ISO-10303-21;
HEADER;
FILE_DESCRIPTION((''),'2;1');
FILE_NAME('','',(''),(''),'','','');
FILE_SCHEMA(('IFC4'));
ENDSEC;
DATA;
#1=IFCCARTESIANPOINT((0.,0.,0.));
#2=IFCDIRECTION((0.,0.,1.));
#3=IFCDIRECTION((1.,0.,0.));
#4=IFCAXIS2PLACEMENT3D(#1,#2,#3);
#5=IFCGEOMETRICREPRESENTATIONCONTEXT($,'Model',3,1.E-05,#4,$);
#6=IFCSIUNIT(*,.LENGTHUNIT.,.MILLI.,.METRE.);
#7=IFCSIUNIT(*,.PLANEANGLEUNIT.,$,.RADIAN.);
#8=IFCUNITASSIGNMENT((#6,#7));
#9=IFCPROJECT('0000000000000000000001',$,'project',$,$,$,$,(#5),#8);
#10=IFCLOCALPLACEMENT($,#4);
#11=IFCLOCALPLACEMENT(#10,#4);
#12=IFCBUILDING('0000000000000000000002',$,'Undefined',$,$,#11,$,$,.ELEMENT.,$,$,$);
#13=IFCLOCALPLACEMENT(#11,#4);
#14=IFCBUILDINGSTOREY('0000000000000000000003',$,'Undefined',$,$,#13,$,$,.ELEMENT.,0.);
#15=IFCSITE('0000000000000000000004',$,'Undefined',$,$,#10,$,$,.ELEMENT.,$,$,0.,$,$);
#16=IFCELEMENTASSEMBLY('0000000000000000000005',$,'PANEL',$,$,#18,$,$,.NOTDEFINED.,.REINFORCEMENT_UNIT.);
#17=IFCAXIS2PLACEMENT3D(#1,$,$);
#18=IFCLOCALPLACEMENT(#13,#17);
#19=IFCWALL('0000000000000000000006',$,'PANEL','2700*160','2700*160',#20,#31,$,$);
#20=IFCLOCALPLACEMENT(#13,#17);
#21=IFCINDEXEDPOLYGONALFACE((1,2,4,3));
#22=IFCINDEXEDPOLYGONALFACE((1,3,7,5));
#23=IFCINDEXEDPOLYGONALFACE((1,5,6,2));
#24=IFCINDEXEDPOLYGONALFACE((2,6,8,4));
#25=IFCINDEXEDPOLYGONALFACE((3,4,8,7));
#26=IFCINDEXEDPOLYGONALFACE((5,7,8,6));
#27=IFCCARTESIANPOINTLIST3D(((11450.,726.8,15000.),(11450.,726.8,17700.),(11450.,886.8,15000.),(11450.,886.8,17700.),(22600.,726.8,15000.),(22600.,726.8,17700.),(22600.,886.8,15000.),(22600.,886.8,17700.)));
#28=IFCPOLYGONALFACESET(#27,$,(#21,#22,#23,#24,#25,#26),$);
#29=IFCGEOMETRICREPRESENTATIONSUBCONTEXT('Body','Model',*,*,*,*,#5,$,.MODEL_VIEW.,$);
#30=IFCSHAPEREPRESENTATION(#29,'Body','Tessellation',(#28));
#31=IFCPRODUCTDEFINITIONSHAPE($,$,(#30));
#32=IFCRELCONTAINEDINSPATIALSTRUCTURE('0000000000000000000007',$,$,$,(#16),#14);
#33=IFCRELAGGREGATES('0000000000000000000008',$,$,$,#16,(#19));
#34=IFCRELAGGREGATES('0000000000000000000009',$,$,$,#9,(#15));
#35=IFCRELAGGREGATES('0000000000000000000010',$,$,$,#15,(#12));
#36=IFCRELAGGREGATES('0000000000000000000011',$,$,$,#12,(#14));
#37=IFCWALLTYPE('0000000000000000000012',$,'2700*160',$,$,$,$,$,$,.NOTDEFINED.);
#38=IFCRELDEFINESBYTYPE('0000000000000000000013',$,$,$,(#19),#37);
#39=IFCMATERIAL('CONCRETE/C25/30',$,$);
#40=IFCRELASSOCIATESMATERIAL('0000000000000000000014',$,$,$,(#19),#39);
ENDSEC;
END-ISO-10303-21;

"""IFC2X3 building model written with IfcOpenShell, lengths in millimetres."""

from ifc_helpers import new_model, si_unit, frame, frame_2d, origin_with_axes, place, context, subcontext, project, spatial, rectangle, extrude, material, type_object, element, aggregate, save


model = new_model("IFC2X3")

# Units and contexts
model_context = context("Model", 3, precision=1e-05, world=origin_with_axes())
body_context = subcontext(model_context, "Body", "Model", "MODEL_VIEW")
ifc_project = project(units=[si_unit("LENGTHUNIT", "METRE", prefix="MILLI"), si_unit("PLANEANGLEUNIT", "RADIAN")], contexts=[model_context])

# Site, building, storey
site_placement = place(None, origin_with_axes())
site = spatial("IfcSite", under=ifc_project, at=site_placement, Name="Undefined", CompositionType="ELEMENT", RefElevation=0.0)
building_placement = place(site_placement, origin_with_axes())
building = spatial("IfcBuilding", under=site, at=building_placement, Name="Undefined", CompositionType="ELEMENT")
storey_placement = place(building_placement, origin_with_axes())
storey = spatial("IfcBuildingStorey", under=building, at=storey_placement, Name="Undefined", CompositionType="ELEMENT", Elevation=0.0)

# Shared definitions
ifc_material = material(Name="CONCRETE/C25/30")

# Element assembly, wall
assembly_1_placement = place(storey_placement, origin_with_axes())
assembly_1 = element("IfcElementAssembly", 1, at=assembly_1_placement, inside=storey, Name="PANEL", AssemblyPlace="NOTDEFINED", PredefinedType="REINFORCEMENT_UNIT")
wall_type_1 = type_object("IfcWallType", Name="2700*160", PredefinedType="NOTDEFINED")
wall_1_placement = place(assembly_1_placement, frame((11450.0, 806.8, 15000.0), z_axis=(0.0, 0.0, 1.0), x_axis=(1.0, 0.0, 0.0)))
wall_1 = element("IfcWall", 2, at=wall_1_placement, type_object=wall_type_1, material=ifc_material, Name="PANEL", Description="2700*160", ObjectType="2700*160", context=body_context, shape_type="SweptSolid", body=[
    extrude(rectangle(XDim=11150.0, YDim=160.0, at=frame_2d((0.0, 5575.0), x_axis=(0.0, -1.0))), frame((0.0, 0.0, 0.0), z_axis=(0.0, 0.0, 1.0), x_axis=(0.0, -1.0, 0.0)), (0.0, 0.0, 1.0), 2700.0),
])
aggregate(assembly_1, [wall_1])

save(model, "model.ifc")
